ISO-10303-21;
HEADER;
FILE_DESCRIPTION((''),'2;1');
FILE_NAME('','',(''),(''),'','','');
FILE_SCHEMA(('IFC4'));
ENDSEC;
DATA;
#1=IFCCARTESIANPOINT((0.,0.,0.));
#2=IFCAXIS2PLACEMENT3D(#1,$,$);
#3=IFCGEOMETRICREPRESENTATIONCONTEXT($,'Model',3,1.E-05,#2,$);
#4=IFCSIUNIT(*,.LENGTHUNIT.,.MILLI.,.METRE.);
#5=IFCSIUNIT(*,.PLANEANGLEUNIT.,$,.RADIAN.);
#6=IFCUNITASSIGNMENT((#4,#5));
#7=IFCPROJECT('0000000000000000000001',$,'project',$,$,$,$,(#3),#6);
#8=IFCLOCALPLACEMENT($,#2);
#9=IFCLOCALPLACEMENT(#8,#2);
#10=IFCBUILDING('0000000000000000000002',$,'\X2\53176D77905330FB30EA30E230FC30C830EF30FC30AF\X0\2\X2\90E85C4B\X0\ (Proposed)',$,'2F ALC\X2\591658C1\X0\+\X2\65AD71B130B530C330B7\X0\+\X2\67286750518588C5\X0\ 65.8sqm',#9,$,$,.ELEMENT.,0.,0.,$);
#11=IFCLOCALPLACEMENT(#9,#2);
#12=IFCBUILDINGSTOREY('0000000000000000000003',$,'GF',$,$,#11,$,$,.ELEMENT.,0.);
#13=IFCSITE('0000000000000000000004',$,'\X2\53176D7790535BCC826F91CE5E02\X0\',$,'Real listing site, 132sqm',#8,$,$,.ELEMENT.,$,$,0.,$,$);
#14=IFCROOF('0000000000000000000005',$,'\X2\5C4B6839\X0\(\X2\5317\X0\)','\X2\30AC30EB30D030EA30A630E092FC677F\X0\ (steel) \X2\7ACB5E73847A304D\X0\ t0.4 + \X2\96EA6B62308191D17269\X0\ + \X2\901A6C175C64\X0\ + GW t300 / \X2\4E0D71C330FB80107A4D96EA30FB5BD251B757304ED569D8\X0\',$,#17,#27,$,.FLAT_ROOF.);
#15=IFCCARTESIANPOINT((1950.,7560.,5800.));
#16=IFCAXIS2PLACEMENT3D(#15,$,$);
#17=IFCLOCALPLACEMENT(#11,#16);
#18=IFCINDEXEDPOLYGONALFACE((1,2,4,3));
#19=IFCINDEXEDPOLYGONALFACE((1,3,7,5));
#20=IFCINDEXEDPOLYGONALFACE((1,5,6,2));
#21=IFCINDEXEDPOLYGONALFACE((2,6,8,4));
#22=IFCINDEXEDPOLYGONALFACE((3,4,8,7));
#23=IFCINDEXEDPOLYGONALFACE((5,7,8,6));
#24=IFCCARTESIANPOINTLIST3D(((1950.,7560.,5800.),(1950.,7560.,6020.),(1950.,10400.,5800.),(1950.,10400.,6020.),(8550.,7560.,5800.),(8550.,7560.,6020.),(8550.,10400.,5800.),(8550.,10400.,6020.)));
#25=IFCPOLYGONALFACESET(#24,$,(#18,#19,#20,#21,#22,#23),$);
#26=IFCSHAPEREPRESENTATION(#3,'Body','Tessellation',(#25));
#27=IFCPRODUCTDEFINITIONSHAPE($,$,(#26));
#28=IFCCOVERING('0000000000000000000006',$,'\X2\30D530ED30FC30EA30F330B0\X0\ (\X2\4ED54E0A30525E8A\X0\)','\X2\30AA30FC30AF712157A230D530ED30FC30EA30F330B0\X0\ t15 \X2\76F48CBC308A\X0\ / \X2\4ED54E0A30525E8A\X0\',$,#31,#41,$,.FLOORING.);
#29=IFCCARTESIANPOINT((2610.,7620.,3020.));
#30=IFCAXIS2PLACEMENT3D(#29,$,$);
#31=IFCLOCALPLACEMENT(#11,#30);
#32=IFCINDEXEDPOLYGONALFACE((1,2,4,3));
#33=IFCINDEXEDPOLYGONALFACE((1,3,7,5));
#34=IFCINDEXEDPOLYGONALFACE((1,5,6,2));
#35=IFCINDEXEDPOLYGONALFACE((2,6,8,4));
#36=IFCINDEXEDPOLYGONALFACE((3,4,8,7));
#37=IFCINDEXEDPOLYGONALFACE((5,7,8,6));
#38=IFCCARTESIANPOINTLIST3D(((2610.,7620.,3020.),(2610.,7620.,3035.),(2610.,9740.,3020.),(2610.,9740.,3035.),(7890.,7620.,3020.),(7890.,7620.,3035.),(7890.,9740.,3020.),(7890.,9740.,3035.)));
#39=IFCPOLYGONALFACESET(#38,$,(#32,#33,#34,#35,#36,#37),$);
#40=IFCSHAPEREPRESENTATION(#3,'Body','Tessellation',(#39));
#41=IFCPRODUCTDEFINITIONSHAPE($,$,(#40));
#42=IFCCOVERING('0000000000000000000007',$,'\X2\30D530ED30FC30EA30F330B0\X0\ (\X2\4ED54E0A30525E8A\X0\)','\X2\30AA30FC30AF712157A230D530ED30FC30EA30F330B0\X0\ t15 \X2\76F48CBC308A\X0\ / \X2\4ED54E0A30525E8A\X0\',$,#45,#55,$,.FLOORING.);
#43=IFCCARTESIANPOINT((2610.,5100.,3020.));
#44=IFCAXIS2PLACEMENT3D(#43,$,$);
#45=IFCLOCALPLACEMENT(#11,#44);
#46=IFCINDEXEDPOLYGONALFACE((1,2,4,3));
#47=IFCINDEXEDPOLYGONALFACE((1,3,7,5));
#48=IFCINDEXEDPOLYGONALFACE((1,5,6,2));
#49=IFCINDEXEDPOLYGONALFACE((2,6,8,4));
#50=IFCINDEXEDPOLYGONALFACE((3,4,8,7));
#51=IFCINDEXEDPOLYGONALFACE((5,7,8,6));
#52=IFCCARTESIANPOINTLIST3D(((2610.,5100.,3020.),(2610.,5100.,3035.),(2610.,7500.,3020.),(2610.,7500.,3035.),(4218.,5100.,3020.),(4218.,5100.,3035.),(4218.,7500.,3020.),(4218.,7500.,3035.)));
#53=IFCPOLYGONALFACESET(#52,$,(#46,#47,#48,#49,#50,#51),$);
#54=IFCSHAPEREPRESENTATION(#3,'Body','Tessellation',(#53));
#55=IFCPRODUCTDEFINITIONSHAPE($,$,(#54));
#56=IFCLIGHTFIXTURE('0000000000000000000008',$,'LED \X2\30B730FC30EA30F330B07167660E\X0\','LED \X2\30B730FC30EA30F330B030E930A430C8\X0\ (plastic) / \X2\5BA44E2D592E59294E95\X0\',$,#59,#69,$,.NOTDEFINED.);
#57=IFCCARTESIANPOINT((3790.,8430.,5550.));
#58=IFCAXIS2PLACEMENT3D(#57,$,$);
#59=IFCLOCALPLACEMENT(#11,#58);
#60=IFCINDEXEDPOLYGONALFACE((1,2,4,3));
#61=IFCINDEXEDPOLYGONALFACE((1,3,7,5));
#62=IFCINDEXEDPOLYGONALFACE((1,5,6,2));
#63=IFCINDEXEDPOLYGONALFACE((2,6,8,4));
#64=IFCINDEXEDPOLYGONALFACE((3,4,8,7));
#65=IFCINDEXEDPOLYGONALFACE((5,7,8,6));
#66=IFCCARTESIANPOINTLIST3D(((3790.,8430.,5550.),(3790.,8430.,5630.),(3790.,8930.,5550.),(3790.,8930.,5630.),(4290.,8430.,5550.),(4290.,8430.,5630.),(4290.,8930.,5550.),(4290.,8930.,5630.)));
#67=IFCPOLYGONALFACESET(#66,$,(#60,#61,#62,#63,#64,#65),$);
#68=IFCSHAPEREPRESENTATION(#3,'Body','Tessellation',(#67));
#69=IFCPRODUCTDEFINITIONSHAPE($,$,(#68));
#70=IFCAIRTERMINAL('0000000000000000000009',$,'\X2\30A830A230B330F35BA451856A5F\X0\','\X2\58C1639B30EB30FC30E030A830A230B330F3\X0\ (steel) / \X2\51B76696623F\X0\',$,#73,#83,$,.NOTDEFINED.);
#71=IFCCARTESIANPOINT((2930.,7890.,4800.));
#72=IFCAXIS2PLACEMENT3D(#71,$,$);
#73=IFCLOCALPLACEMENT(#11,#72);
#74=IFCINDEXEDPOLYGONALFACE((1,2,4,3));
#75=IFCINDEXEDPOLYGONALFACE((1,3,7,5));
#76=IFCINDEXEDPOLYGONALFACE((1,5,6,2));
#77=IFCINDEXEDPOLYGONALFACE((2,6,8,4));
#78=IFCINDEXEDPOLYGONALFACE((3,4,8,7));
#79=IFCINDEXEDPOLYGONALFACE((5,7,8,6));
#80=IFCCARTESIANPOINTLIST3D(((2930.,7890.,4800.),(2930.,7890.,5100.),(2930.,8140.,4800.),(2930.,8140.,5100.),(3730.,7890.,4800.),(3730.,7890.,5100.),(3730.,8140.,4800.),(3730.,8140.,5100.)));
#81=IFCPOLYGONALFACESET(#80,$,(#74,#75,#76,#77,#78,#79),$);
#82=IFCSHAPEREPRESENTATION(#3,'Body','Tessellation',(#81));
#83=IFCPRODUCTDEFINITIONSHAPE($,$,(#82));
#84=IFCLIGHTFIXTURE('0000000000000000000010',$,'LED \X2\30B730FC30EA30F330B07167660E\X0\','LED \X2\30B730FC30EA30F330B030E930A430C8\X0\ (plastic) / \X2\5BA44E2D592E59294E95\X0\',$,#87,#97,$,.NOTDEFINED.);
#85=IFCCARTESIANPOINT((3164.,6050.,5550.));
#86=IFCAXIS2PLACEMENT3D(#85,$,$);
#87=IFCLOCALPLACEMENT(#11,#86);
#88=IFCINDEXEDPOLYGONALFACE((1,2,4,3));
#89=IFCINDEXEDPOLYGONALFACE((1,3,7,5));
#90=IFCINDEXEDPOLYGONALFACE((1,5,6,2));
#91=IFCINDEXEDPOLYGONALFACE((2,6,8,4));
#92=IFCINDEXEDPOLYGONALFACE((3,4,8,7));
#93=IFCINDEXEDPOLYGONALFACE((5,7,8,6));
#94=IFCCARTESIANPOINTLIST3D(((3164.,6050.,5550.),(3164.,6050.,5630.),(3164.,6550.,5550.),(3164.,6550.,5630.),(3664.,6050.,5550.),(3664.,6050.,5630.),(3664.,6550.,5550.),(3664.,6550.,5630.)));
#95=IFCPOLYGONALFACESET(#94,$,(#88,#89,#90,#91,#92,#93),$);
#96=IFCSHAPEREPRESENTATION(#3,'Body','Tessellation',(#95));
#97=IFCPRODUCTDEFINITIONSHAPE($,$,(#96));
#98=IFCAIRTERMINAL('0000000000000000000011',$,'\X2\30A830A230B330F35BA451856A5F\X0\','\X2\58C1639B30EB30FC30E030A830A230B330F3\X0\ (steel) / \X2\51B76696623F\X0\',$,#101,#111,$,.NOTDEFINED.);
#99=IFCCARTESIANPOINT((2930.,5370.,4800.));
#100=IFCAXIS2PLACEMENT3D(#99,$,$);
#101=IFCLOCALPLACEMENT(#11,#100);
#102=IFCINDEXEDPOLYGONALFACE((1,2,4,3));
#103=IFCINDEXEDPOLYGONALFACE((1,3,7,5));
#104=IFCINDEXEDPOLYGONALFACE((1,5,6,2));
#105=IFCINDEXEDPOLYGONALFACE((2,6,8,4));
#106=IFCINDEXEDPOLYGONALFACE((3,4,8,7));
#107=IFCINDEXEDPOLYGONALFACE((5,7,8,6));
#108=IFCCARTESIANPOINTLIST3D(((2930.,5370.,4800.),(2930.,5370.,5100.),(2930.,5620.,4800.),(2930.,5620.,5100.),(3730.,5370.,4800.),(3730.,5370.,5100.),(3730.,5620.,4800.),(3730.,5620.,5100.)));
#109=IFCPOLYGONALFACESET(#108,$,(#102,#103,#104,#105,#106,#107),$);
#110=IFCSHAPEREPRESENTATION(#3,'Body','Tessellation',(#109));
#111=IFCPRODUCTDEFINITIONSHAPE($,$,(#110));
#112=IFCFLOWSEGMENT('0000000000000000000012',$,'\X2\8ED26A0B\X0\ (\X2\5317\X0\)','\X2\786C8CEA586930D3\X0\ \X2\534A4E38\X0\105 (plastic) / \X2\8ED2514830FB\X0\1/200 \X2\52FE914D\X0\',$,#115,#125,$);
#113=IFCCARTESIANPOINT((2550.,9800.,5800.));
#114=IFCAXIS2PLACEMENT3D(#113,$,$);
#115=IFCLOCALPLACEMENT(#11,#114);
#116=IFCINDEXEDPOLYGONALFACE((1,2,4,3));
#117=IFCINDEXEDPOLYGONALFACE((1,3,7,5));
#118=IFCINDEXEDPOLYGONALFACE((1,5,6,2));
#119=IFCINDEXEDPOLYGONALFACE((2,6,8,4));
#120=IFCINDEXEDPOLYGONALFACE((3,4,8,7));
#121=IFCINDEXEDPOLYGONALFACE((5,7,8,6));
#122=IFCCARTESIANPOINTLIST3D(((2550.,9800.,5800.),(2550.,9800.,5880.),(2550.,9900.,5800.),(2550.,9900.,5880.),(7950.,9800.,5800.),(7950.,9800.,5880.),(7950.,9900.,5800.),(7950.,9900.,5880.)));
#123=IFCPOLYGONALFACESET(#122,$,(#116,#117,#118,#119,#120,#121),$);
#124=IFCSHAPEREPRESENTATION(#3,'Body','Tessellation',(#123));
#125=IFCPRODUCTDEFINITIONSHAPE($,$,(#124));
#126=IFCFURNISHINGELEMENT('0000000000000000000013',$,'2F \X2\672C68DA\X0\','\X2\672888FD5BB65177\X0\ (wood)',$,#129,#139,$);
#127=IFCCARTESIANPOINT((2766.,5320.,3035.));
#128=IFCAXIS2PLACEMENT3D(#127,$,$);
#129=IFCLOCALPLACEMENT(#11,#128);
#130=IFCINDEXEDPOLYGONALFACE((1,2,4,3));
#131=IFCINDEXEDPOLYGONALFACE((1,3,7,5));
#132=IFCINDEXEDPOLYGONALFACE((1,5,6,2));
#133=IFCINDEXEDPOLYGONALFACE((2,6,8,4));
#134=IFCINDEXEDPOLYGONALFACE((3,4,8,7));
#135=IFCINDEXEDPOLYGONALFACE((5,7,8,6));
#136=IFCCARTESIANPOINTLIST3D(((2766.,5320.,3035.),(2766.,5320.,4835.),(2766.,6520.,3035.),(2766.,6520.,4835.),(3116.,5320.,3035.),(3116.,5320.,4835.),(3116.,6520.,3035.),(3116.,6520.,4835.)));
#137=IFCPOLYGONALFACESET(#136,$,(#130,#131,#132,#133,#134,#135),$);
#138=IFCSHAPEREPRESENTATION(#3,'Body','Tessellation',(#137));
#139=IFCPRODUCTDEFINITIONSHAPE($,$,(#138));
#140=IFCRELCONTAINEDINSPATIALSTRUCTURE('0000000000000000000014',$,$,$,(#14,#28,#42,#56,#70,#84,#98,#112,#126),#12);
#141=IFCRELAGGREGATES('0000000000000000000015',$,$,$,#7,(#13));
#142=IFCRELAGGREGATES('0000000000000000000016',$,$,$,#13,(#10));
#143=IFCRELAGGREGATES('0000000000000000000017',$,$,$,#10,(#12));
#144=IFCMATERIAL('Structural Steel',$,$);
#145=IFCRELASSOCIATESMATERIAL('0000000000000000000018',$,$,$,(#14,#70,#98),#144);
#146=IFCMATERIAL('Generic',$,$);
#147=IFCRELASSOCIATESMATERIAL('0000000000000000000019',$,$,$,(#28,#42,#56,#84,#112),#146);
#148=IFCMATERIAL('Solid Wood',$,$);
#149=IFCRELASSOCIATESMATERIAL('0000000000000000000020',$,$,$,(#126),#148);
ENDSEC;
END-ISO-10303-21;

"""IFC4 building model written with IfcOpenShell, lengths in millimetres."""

from ifc_helpers import new_model, si_unit, frame, frame_2d, origin, place, context, project, spatial, rectangle, extrude, material, element, save


model = new_model("IFC4")

# Units and contexts
model_context = context("Model", 3, precision=1e-05, world=origin())
ifc_project = project(units=[si_unit("LENGTHUNIT", "METRE", prefix="MILLI"), si_unit("PLANEANGLEUNIT", "RADIAN")], contexts=[model_context])

# Site, building, storey
site_placement = place(None, origin())
site = spatial("IfcSite", under=ifc_project, at=site_placement, Name="北海道富良野市", ObjectType="Real listing site, 132sqm", CompositionType="ELEMENT", RefElevation=0.0)
building_placement = place(site_placement, origin())
building = spatial("IfcBuilding", under=site, at=building_placement, Name="北海道・リモートワーク2部屋 (Proposed)", ObjectType="2F ALC外壁+断熱サッシ+木材内装 65.8sqm", CompositionType="ELEMENT", ElevationOfRefHeight=0.0, ElevationOfTerrain=0.0)
storey_placement = place(building_placement, origin())
storey = spatial("IfcBuildingStorey", under=building, at=storey_placement, Name="GF", CompositionType="ELEMENT", Elevation=0.0)

# Shared definitions
ifc_material_1 = material(Name="Solid Wood")

# Roof
ifc_material_2 = material(Name="Structural Steel")
for number, where, name in (
    (1, (1950.0, 7560.0, 5800.0), "屋根(北)"),
):
    element("IfcRoof", number, at=place(storey_placement, frame(where)), inside=storey, material=ifc_material_2, Name=name, Description="ガルバリウム鋼板 (steel) 立平葺き t0.4 + 雪止め金物 + 通気層 + GW t300 / 不燃・耐積雪・寒冷地仕様", PredefinedType="FLAT_ROOF", context=model_context, shape_type="SweptSolid", body=[
        extrude(rectangle(XDim=6600.0, YDim=2840.0, at=frame_2d((3300.0, 1420.0))), frame((1950.0, 7560.0, 5800.0)), (0.0, 0.0, 1.0), 220.0),
    ])

# Coverings
ifc_material_3 = material(Name="Generic")
covering_1_placement = place(storey_placement, frame((2610.0, 7620.0, 3020.0)))
element("IfcCovering", 2, at=covering_1_placement, inside=storey, material=ifc_material_3, Name="フローリング (仕上げ床)", Description="オーク無垢フローリング t15 直貼り / 仕上げ床", PredefinedType="FLOORING", context=model_context, shape_type="SweptSolid", body=[
    extrude(rectangle(XDim=5280.0, YDim=2120.0, at=frame_2d((2640.0, 1060.0))), frame((2610.0, 7620.0, 3020.0)), (0.0, 0.0, 1.0), 15.0),
])
covering_2_placement = place(storey_placement, frame((2610.0, 5100.0, 3020.0)))
element("IfcCovering", 3, at=covering_2_placement, inside=storey, material=ifc_material_3, Name="フローリング (仕上げ床)", Description="オーク無垢フローリング t15 直貼り / 仕上げ床", PredefinedType="FLOORING", context=model_context, shape_type="SweptSolid", body=[
    extrude(rectangle(XDim=1608.0, YDim=2400.0, at=frame_2d((804.0, 1200.0))), frame((2610.0, 5100.0, 3020.0)), (0.0, 0.0, 1.0), 15.0),
])

# Light fixture
light_fixture_1_placement = place(storey_placement, frame((3790.0, 8430.0, 5550.0)))
element("IfcLightFixture", 4, at=light_fixture_1_placement, inside=storey, material=ifc_material_3, Name="LED シーリング照明", Description="LED シーリングライト (plastic) / 室中央天井", PredefinedType="NOTDEFINED", context=model_context, shape_type="SweptSolid", body=[
    extrude(rectangle(XDim=500.0, YDim=500.0, at=frame_2d((250.0, 250.0))), frame((3790.0, 8430.0, 5550.0)), (0.0, 0.0, 1.0), 80.0),
])

# Air terminal
air_terminal_1_placement = place(storey_placement, frame((2930.0, 7890.0, 4800.0)))
element("IfcAirTerminal", 5, at=air_terminal_1_placement, inside=storey, material=ifc_material_2, Name="エアコン室内機", Description="壁掛ルームエアコン (steel) / 冷暖房", PredefinedType="NOTDEFINED", context=model_context, shape_type="SweptSolid", body=[
    extrude(rectangle(XDim=800.0, YDim=250.0, at=frame_2d((400.0, 125.0))), frame((2930.0, 7890.0, 4800.0)), (0.0, 0.0, 1.0), 300.0),
])

# Light fixture
light_fixture_2_placement = place(storey_placement, frame((3164.0, 6050.0, 5550.0)))
element("IfcLightFixture", 6, at=light_fixture_2_placement, inside=storey, material=ifc_material_3, Name="LED シーリング照明", Description="LED シーリングライト (plastic) / 室中央天井", PredefinedType="NOTDEFINED", context=model_context, shape_type="SweptSolid", body=[
    extrude(rectangle(XDim=500.0, YDim=500.0, at=frame_2d((250.0, 250.0))), frame((3164.0, 6050.0, 5550.0)), (0.0, 0.0, 1.0), 80.0),
])

# Air terminal
air_terminal_2_placement = place(storey_placement, frame((2930.0, 5370.0, 4800.0)))
element("IfcAirTerminal", 7, at=air_terminal_2_placement, inside=storey, material=ifc_material_2, Name="エアコン室内機", Description="壁掛ルームエアコン (steel) / 冷暖房", PredefinedType="NOTDEFINED", context=model_context, shape_type="SweptSolid", body=[
    extrude(rectangle(XDim=800.0, YDim=250.0, at=frame_2d((400.0, 125.0))), frame((2930.0, 5370.0, 4800.0)), (0.0, 0.0, 1.0), 300.0),
])

# Flow segment
flow_segment_placement = place(storey_placement, frame((2550.0, 9800.0, 5800.0)))
element("IfcFlowSegment", 8, at=flow_segment_placement, inside=storey, material=ifc_material_3, Name="軒樋 (北)", Description="硬質塩ビ 半丸105 (plastic) / 軒先・1/200 勾配", context=model_context, shape_type="SweptSolid", body=[
    extrude(rectangle(XDim=5400.0, YDim=100.0, at=frame_2d((2700.0, 50.0))), frame((2550.0, 9800.0, 5800.0)), (0.0, 0.0, 1.0), 80.0),
])

# Furnishing element
furnishing_placement = place(storey_placement, frame((2766.0, 5320.0, 3035.0)))
element("IfcFurnishingElement", 9, at=furnishing_placement, inside=storey, material=ifc_material_1, Name="2F 本棚", Description="木製家具 (wood)", context=model_context, shape_type="SweptSolid", body=[
    extrude(rectangle(XDim=350.0, YDim=1200.0, at=frame_2d((175.0, 600.0))), frame((2766.0, 5320.0, 3035.0)), (0.0, 0.0, 1.0), 1800.0),
])

save(model, "model.ifc")
